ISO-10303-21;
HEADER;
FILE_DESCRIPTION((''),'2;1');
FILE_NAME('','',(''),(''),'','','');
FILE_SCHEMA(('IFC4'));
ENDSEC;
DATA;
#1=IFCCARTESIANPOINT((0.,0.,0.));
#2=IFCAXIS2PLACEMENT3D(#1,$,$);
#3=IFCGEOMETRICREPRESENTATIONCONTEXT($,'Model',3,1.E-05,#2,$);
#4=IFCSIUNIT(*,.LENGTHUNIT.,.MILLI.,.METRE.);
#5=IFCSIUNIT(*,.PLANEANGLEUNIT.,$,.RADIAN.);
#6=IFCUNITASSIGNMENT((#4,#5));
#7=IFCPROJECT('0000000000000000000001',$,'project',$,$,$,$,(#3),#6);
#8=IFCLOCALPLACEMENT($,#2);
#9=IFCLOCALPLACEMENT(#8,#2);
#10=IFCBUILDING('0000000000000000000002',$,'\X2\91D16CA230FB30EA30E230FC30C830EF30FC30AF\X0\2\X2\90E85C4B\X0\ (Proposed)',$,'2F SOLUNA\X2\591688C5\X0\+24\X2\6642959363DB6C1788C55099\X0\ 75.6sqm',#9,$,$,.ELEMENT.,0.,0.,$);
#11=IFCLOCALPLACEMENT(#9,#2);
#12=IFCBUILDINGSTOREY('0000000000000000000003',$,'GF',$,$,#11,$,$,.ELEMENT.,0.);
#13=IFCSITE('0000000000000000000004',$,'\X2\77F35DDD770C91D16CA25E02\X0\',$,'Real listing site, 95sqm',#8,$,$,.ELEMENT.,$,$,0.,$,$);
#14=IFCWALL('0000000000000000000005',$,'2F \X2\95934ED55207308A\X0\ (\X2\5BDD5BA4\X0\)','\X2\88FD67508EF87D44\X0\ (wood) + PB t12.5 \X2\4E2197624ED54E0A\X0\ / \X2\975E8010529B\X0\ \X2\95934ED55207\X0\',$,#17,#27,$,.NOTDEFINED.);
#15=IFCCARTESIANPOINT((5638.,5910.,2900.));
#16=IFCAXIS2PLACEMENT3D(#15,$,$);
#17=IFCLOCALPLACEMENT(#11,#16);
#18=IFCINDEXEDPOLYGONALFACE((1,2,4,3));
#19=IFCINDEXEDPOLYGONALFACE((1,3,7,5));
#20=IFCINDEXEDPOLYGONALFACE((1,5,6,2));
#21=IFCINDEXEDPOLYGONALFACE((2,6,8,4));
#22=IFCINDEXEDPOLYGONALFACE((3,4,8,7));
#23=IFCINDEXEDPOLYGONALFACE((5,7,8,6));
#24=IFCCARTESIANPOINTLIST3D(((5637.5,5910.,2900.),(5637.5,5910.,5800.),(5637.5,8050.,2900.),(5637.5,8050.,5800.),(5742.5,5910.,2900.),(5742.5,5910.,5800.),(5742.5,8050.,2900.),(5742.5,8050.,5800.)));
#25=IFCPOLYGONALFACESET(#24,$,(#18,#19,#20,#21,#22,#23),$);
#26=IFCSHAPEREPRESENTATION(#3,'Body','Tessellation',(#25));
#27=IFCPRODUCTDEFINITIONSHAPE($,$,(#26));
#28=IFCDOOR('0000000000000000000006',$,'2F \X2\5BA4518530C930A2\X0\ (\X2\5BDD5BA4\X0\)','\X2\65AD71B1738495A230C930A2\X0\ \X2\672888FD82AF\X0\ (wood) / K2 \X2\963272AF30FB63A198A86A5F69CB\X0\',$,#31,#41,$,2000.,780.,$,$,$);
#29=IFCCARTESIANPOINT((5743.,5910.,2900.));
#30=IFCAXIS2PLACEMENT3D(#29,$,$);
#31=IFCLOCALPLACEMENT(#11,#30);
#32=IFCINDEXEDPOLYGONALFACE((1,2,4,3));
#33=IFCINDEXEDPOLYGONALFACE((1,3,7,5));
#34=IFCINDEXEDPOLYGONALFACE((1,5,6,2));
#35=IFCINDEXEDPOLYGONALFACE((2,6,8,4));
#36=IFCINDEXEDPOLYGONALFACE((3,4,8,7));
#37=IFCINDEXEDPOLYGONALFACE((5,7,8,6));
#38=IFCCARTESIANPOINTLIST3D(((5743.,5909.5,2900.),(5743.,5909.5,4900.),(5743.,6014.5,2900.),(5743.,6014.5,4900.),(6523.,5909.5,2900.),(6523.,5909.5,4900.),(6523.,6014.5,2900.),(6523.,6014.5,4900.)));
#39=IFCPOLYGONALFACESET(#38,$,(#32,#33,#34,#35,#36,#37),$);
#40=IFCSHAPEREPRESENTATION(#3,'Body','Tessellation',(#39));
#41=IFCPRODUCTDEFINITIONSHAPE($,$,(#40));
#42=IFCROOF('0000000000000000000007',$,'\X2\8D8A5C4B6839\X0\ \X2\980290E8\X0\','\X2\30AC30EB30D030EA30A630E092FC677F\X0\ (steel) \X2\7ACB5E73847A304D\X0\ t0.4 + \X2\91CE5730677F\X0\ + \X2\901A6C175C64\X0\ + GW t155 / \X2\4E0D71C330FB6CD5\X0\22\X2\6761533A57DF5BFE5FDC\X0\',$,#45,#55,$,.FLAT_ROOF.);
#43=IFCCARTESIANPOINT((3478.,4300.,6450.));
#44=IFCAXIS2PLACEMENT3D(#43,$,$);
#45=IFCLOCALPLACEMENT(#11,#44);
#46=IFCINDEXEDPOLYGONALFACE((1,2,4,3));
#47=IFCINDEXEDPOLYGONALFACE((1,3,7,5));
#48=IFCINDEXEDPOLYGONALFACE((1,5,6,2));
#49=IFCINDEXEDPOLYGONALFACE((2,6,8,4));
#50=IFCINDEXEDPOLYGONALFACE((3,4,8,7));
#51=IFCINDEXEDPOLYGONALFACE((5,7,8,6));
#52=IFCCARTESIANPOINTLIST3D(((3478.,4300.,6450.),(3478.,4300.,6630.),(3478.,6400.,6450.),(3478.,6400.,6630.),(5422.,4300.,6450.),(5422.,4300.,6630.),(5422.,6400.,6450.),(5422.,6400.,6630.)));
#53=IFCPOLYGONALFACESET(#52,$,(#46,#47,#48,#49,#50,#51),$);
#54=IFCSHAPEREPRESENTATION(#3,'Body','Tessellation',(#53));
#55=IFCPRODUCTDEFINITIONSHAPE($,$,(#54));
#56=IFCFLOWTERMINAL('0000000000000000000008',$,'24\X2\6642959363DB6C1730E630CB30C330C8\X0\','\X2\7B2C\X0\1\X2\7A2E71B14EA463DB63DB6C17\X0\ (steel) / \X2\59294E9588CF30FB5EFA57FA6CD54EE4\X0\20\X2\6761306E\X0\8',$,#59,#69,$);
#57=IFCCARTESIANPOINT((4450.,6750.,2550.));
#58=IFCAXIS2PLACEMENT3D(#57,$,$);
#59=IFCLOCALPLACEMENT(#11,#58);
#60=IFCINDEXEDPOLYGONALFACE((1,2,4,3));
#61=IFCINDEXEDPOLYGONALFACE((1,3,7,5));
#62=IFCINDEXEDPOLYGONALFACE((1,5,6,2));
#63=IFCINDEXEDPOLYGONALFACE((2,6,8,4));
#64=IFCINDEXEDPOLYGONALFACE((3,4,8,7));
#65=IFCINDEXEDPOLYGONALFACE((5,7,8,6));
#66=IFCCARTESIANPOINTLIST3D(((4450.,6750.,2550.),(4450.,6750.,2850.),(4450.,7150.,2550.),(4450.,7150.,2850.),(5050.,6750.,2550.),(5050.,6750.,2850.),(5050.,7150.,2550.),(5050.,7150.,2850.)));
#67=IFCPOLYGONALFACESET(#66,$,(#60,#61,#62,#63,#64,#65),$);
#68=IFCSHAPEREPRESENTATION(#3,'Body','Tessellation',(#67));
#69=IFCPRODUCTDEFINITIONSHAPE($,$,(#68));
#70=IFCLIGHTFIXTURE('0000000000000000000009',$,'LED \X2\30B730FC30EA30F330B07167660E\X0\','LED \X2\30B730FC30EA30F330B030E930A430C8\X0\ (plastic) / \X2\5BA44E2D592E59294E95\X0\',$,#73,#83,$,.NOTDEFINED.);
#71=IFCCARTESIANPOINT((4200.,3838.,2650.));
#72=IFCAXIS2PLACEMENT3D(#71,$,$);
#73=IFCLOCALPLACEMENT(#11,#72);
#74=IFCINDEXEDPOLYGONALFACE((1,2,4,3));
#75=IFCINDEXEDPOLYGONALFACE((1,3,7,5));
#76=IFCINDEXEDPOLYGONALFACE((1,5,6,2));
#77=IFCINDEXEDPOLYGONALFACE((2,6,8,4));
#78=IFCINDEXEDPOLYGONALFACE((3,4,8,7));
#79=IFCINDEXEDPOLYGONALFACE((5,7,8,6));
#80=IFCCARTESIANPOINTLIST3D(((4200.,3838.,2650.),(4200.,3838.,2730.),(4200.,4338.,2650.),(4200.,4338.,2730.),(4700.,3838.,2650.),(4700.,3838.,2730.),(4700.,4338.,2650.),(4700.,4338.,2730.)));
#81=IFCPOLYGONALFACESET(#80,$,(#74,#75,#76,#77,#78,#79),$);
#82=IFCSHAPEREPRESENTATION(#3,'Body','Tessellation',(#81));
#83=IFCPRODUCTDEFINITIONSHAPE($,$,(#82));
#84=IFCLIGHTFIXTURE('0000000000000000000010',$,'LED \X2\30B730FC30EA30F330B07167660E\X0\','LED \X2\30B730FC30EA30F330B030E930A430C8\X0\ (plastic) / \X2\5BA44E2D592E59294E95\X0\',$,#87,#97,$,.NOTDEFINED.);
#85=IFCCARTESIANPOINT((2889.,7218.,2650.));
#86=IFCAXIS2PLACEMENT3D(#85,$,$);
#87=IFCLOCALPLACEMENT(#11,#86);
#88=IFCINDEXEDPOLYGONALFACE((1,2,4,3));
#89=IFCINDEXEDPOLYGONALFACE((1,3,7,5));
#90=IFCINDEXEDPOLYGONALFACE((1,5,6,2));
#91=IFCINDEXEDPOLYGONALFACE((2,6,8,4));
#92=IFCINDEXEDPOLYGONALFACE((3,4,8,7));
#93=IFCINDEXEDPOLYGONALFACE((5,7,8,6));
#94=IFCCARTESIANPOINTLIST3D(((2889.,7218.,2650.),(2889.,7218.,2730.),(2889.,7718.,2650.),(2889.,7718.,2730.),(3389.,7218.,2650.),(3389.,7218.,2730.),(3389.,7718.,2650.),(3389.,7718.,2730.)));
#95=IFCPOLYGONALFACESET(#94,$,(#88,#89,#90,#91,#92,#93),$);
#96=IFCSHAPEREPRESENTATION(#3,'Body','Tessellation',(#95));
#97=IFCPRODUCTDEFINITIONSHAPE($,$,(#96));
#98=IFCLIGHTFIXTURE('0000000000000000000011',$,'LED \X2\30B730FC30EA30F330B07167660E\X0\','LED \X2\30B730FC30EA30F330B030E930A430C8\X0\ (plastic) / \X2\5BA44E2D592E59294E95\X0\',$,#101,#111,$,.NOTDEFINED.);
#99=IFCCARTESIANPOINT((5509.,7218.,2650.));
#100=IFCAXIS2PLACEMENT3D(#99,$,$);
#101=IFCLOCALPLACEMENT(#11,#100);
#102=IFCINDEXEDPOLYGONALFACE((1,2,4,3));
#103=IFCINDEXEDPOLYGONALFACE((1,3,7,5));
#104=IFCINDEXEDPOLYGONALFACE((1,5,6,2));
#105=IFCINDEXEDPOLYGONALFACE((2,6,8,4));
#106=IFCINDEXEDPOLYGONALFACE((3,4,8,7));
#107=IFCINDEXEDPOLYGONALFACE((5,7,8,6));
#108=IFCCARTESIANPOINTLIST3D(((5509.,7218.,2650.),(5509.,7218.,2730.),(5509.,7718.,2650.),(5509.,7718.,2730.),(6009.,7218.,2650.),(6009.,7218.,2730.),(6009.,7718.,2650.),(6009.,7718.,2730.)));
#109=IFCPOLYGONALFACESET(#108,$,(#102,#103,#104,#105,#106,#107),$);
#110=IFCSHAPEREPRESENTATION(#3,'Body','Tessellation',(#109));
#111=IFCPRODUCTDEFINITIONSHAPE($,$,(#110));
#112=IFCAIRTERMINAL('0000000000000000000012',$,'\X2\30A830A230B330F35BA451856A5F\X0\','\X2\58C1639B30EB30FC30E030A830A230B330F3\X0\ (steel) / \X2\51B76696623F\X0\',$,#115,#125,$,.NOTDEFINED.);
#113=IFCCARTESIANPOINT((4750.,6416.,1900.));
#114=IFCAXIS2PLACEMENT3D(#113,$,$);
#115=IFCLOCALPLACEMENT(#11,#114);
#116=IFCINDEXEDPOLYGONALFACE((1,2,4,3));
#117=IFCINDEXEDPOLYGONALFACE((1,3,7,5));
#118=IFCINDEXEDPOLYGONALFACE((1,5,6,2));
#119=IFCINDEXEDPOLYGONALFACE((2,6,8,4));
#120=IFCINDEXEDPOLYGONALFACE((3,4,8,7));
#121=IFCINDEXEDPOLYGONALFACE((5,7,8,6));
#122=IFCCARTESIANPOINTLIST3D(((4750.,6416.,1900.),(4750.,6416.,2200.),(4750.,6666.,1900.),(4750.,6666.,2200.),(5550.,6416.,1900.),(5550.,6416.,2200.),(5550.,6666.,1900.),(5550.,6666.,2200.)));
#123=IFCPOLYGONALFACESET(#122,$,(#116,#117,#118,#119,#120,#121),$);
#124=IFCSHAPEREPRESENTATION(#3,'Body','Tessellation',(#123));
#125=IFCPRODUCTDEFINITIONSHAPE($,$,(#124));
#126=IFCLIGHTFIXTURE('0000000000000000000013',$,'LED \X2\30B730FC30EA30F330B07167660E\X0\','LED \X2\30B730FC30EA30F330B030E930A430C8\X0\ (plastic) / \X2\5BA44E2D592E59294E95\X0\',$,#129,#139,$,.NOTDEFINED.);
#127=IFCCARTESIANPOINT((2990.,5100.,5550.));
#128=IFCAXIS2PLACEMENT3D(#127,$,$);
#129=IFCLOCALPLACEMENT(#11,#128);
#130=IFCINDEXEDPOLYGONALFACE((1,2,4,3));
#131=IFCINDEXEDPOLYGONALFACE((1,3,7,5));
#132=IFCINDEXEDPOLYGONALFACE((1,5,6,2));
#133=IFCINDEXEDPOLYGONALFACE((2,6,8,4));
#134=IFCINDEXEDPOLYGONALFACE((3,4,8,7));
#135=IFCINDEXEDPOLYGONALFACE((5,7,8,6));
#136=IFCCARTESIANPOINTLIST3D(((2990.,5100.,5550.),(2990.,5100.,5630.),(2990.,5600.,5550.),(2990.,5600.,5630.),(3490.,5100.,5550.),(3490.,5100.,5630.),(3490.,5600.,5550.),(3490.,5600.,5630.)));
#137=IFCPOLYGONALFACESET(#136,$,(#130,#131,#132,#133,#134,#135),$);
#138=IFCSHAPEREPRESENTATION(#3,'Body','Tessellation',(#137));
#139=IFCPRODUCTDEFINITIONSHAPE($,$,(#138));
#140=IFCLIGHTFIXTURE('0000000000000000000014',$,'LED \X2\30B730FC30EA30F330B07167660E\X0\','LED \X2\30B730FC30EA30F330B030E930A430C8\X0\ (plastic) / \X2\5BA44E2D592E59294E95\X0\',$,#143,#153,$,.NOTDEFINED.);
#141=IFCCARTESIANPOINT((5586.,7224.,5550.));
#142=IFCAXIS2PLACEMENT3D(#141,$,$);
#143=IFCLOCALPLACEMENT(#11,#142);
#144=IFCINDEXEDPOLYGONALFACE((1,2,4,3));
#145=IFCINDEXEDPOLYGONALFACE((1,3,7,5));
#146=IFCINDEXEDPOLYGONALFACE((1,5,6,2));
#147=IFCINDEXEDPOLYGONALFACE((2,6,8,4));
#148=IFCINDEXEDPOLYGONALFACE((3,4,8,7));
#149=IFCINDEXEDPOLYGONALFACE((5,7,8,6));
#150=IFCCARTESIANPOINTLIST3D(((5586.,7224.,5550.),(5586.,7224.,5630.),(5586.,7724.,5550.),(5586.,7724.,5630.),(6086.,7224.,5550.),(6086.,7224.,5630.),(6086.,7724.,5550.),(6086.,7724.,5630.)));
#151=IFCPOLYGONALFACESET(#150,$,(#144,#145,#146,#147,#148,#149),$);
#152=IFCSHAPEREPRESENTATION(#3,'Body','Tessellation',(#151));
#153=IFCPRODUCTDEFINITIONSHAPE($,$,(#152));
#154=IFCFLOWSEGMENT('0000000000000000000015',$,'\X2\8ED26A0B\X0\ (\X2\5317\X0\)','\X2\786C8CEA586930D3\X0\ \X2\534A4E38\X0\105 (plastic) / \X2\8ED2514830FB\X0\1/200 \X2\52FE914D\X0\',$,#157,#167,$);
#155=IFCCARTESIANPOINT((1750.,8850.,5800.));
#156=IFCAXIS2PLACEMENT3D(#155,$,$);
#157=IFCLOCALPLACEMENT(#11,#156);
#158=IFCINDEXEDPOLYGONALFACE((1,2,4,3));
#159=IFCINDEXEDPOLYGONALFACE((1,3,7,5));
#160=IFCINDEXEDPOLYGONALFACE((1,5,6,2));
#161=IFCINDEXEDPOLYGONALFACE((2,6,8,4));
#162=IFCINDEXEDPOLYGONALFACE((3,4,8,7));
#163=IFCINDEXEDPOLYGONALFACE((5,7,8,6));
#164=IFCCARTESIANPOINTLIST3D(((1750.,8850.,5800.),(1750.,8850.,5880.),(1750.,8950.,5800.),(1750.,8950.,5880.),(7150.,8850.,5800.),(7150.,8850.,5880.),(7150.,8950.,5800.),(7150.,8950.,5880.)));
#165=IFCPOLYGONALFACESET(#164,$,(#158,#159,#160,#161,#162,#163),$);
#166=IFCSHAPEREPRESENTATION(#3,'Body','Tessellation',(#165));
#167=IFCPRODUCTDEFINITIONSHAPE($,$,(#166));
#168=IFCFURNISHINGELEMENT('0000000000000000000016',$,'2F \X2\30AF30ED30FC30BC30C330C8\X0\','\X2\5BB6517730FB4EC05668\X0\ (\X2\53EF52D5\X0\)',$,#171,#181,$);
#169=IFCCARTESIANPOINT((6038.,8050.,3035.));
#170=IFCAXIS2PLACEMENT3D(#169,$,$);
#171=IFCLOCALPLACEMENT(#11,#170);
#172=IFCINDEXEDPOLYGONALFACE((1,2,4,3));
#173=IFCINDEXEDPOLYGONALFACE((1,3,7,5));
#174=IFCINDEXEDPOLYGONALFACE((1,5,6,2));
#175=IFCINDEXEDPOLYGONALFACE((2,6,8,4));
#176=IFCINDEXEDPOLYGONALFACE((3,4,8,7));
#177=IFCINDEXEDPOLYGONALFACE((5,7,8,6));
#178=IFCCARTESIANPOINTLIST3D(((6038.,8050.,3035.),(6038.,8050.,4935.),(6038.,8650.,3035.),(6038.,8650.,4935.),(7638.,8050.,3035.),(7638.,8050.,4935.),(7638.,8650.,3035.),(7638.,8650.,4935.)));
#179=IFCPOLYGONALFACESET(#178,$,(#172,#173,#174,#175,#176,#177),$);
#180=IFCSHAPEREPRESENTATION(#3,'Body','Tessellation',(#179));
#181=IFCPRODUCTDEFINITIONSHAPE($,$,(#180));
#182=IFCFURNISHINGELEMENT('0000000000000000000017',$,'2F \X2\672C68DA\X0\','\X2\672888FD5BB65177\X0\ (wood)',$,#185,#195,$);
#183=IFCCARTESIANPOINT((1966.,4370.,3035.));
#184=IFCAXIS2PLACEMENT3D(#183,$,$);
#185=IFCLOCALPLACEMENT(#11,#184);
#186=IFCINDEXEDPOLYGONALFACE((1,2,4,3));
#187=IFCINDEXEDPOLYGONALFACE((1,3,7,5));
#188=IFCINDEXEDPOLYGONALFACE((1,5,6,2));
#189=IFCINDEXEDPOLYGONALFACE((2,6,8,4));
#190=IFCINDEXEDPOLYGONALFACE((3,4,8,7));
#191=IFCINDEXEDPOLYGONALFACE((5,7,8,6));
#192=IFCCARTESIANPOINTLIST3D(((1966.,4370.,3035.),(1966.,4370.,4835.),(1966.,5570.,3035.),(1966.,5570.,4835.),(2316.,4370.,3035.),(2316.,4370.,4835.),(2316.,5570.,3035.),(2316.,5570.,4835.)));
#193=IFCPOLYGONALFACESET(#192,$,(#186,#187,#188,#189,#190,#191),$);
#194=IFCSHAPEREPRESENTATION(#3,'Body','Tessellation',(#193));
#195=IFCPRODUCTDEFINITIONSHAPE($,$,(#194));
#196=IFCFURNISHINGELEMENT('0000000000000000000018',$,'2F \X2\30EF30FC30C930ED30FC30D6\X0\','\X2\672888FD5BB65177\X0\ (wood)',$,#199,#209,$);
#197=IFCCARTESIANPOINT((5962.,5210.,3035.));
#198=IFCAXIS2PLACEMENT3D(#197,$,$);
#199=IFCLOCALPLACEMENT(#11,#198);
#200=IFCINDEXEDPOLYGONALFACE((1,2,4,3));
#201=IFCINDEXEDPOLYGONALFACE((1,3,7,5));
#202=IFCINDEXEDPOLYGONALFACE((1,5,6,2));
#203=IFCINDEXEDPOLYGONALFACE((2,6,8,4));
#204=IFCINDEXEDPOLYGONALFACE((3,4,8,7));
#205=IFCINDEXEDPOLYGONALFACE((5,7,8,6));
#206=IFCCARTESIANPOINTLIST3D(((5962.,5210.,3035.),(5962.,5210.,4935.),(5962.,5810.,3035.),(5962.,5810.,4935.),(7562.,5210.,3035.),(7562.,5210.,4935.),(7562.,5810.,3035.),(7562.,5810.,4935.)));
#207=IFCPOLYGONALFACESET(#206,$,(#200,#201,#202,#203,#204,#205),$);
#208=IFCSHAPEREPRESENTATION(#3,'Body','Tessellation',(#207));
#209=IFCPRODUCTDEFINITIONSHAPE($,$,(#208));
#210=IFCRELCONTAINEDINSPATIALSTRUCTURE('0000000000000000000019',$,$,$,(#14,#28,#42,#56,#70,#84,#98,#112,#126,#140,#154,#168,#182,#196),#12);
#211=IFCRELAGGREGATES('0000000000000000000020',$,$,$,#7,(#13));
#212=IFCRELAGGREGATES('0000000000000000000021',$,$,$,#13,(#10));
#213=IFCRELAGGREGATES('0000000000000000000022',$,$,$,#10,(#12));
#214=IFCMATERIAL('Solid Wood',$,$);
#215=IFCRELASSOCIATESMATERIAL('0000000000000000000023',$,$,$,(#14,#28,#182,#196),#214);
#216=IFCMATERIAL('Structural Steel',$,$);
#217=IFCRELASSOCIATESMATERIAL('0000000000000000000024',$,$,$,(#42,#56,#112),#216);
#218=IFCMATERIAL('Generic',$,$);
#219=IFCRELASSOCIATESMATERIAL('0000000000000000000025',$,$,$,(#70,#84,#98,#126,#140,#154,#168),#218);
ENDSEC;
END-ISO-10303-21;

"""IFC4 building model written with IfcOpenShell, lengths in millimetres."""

from ifc_helpers import new_model, si_unit, frame, frame_2d, origin, place, context, project, spatial, rectangle, extrude, material, element, save


model = new_model("IFC4")

# Units and contexts
model_context = context("Model", 3, precision=1e-05, world=origin())
ifc_project = project(units=[si_unit("LENGTHUNIT", "METRE", prefix="MILLI"), si_unit("PLANEANGLEUNIT", "RADIAN")], contexts=[model_context])

# Site, building, storey
site_placement = place(None, origin())
site = spatial("IfcSite", under=ifc_project, at=site_placement, Name="石川県金沢市", ObjectType="Real listing site, 95sqm", CompositionType="ELEMENT", RefElevation=0.0)
building_placement = place(site_placement, origin())
building = spatial("IfcBuilding", under=site, at=building_placement, Name="金沢・リモートワーク2部屋 (Proposed)", ObjectType="2F SOLUNA外装+24時間換気装備 75.6sqm", CompositionType="ELEMENT", ElevationOfRefHeight=0.0, ElevationOfTerrain=0.0)
storey_placement = place(building_placement, origin())
storey = spatial("IfcBuildingStorey", under=building, at=storey_placement, Name="GF", CompositionType="ELEMENT", Elevation=0.0)

# Shared definitions
ifc_material_1 = material(Name="Solid Wood")

# Wall
wall_1_placement = place(storey_placement, frame((5638.0, 5910.0, 2900.0)))
element("IfcWall", 1, at=wall_1_placement, inside=storey, material=ifc_material_1, Name="2F 間仕切り (寝室)", Description="製材軸組 (wood) + PB t12.5 両面仕上 / 非耐力 間仕切", PredefinedType="NOTDEFINED", context=model_context, shape_type="SweptSolid", body=[
    extrude(rectangle(XDim=105.0, YDim=2140.0, at=frame_2d((52.0, 1070.0))), frame((5638.0, 5910.0, 2900.0)), (0.0, 0.0, 1.0), 2900.0),
])

# Door
door_placement = place(storey_placement, frame((5743.0, 5910.0, 2900.0)))
element("IfcDoor", 2, at=door_placement, inside=storey, material=ifc_material_1, Name="2F 室内ドア (寝室)", Description="断熱玄関ドア 木製芯 (wood) / K2 防犯・採風機構", OverallHeight=2000.0, OverallWidth=780.0, context=model_context, shape_type="SweptSolid", body=[
    extrude(rectangle(XDim=780.0, YDim=105.0, at=frame_2d((390.0, 52.0))), frame((5743.0, 5910.0, 2900.0)), (0.0, 0.0, 1.0), 2000.0),
])

# Roof
ifc_material_2 = material(Name="Structural Steel")
roof_placement = place(storey_placement, frame((3478.0, 4300.0, 6450.0)))
element("IfcRoof", 3, at=roof_placement, inside=storey, material=ifc_material_2, Name="越屋根 頂部", Description="ガルバリウム鋼板 (steel) 立平葺き t0.4 + 野地板 + 通気層 + GW t155 / 不燃・法22条区域対応", PredefinedType="FLAT_ROOF", context=model_context, shape_type="SweptSolid", body=[
    extrude(rectangle(XDim=1944.0, YDim=2100.0, at=frame_2d((972.0, 1050.0))), frame((3478.0, 4300.0, 6450.0)), (0.0, 0.0, 1.0), 180.0),
])

# Flow terminal
flow_terminal_placement = place(storey_placement, frame((4450.0, 6750.0, 2550.0)))
element("IfcFlowTerminal", 4, at=flow_terminal_placement, inside=storey, material=ifc_material_2, Name="24時間換気ユニット", Description="第1種熱交換換気 (steel) / 天井裏・建基法令20条の8", context=model_context, shape_type="SweptSolid", body=[
    extrude(rectangle(XDim=600.0, YDim=400.0, at=frame_2d((300.0, 200.0))), frame((4450.0, 6750.0, 2550.0)), (0.0, 0.0, 1.0), 300.0),
])

# Light fixtures
ifc_material_3 = material(Name="Generic")
light_fixture_1_placement = place(storey_placement, frame((4200.0, 3838.0, 2650.0)))
element("IfcLightFixture", 5, at=light_fixture_1_placement, inside=storey, material=ifc_material_3, Name="LED シーリング照明", Description="LED シーリングライト (plastic) / 室中央天井", PredefinedType="NOTDEFINED", context=model_context, shape_type="SweptSolid", body=[
    extrude(rectangle(XDim=500.0, YDim=500.0, at=frame_2d((250.0, 250.0))), frame((4200.0, 3838.0, 2650.0)), (0.0, 0.0, 1.0), 80.0),
])
light_fixture_2_placement = place(storey_placement, frame((2889.0, 7218.0, 2650.0)))
element("IfcLightFixture", 6, at=light_fixture_2_placement, inside=storey, material=ifc_material_3, Name="LED シーリング照明", Description="LED シーリングライト (plastic) / 室中央天井", PredefinedType="NOTDEFINED", context=model_context, shape_type="SweptSolid", body=[
    extrude(rectangle(XDim=500.0, YDim=500.0, at=frame_2d((250.0, 250.0))), frame((2889.0, 7218.0, 2650.0)), (0.0, 0.0, 1.0), 80.0),
])
light_fixture_3_placement = place(storey_placement, frame((5509.0, 7218.0, 2650.0)))
element("IfcLightFixture", 7, at=light_fixture_3_placement, inside=storey, material=ifc_material_3, Name="LED シーリング照明", Description="LED シーリングライト (plastic) / 室中央天井", PredefinedType="NOTDEFINED", context=model_context, shape_type="SweptSolid", body=[
    extrude(rectangle(XDim=500.0, YDim=500.0, at=frame_2d((250.0, 250.0))), frame((5509.0, 7218.0, 2650.0)), (0.0, 0.0, 1.0), 80.0),
])

# Air terminal
air_terminal_placement = place(storey_placement, frame((4750.0, 6416.0, 1900.0)))
element("IfcAirTerminal", 8, at=air_terminal_placement, inside=storey, material=ifc_material_2, Name="エアコン室内機", Description="壁掛ルームエアコン (steel) / 冷暖房", PredefinedType="NOTDEFINED", context=model_context, shape_type="SweptSolid", body=[
    extrude(rectangle(XDim=800.0, YDim=250.0, at=frame_2d((400.0, 125.0))), frame((4750.0, 6416.0, 1900.0)), (0.0, 0.0, 1.0), 300.0),
])

# Light fixtures
light_fixture_4_placement = place(storey_placement, frame((2990.0, 5100.0, 5550.0)))
element("IfcLightFixture", 9, at=light_fixture_4_placement, inside=storey, material=ifc_material_3, Name="LED シーリング照明", Description="LED シーリングライト (plastic) / 室中央天井", PredefinedType="NOTDEFINED", context=model_context, shape_type="SweptSolid", body=[
    extrude(rectangle(XDim=500.0, YDim=500.0, at=frame_2d((250.0, 250.0))), frame((2990.0, 5100.0, 5550.0)), (0.0, 0.0, 1.0), 80.0),
])
light_fixture_5_placement = place(storey_placement, frame((5586.0, 7224.0, 5550.0)))
element("IfcLightFixture", 10, at=light_fixture_5_placement, inside=storey, material=ifc_material_3, Name="LED シーリング照明", Description="LED シーリングライト (plastic) / 室中央天井", PredefinedType="NOTDEFINED", context=model_context, shape_type="SweptSolid", body=[
    extrude(rectangle(XDim=500.0, YDim=500.0, at=frame_2d((250.0, 250.0))), frame((5586.0, 7224.0, 5550.0)), (0.0, 0.0, 1.0), 80.0),
])

# Flow segment
flow_segment_placement = place(storey_placement, frame((1750.0, 8850.0, 5800.0)))
element("IfcFlowSegment", 11, at=flow_segment_placement, inside=storey, material=ifc_material_3, Name="軒樋 (北)", Description="硬質塩ビ 半丸105 (plastic) / 軒先・1/200 勾配", context=model_context, shape_type="SweptSolid", body=[
    extrude(rectangle(XDim=5400.0, YDim=100.0, at=frame_2d((2700.0, 50.0))), frame((1750.0, 8850.0, 5800.0)), (0.0, 0.0, 1.0), 80.0),
])

# Furnishing elements
furnishing_1_placement = place(storey_placement, frame((6038.0, 8050.0, 3035.0)))
element("IfcFurnishingElement", 12, at=furnishing_1_placement, inside=storey, material=ifc_material_3, Name="2F クローゼット", Description="家具・什器 (可動)", context=model_context, shape_type="SweptSolid", body=[
    extrude(rectangle(XDim=1600.0, YDim=600.0, at=frame_2d((800.0, 300.0))), frame((6038.0, 8050.0, 3035.0)), (0.0, 0.0, 1.0), 1900.0),
])
furnishing_2_placement = place(storey_placement, frame((1966.0, 4370.0, 3035.0)))
element("IfcFurnishingElement", 13, at=furnishing_2_placement, inside=storey, material=ifc_material_1, Name="2F 本棚", Description="木製家具 (wood)", context=model_context, shape_type="SweptSolid", body=[
    extrude(rectangle(XDim=350.0, YDim=1200.0, at=frame_2d((175.0, 600.0))), frame((1966.0, 4370.0, 3035.0)), (0.0, 0.0, 1.0), 1800.0),
])
furnishing_3_placement = place(storey_placement, frame((5962.0, 5210.0, 3035.0)))
element("IfcFurnishingElement", 14, at=furnishing_3_placement, inside=storey, material=ifc_material_1, Name="2F ワードローブ", Description="木製家具 (wood)", context=model_context, shape_type="SweptSolid", body=[
    extrude(rectangle(XDim=1600.0, YDim=600.0, at=frame_2d((800.0, 300.0))), frame((5962.0, 5210.0, 3035.0)), (0.0, 0.0, 1.0), 1900.0),
])

save(model, "model.ifc")
